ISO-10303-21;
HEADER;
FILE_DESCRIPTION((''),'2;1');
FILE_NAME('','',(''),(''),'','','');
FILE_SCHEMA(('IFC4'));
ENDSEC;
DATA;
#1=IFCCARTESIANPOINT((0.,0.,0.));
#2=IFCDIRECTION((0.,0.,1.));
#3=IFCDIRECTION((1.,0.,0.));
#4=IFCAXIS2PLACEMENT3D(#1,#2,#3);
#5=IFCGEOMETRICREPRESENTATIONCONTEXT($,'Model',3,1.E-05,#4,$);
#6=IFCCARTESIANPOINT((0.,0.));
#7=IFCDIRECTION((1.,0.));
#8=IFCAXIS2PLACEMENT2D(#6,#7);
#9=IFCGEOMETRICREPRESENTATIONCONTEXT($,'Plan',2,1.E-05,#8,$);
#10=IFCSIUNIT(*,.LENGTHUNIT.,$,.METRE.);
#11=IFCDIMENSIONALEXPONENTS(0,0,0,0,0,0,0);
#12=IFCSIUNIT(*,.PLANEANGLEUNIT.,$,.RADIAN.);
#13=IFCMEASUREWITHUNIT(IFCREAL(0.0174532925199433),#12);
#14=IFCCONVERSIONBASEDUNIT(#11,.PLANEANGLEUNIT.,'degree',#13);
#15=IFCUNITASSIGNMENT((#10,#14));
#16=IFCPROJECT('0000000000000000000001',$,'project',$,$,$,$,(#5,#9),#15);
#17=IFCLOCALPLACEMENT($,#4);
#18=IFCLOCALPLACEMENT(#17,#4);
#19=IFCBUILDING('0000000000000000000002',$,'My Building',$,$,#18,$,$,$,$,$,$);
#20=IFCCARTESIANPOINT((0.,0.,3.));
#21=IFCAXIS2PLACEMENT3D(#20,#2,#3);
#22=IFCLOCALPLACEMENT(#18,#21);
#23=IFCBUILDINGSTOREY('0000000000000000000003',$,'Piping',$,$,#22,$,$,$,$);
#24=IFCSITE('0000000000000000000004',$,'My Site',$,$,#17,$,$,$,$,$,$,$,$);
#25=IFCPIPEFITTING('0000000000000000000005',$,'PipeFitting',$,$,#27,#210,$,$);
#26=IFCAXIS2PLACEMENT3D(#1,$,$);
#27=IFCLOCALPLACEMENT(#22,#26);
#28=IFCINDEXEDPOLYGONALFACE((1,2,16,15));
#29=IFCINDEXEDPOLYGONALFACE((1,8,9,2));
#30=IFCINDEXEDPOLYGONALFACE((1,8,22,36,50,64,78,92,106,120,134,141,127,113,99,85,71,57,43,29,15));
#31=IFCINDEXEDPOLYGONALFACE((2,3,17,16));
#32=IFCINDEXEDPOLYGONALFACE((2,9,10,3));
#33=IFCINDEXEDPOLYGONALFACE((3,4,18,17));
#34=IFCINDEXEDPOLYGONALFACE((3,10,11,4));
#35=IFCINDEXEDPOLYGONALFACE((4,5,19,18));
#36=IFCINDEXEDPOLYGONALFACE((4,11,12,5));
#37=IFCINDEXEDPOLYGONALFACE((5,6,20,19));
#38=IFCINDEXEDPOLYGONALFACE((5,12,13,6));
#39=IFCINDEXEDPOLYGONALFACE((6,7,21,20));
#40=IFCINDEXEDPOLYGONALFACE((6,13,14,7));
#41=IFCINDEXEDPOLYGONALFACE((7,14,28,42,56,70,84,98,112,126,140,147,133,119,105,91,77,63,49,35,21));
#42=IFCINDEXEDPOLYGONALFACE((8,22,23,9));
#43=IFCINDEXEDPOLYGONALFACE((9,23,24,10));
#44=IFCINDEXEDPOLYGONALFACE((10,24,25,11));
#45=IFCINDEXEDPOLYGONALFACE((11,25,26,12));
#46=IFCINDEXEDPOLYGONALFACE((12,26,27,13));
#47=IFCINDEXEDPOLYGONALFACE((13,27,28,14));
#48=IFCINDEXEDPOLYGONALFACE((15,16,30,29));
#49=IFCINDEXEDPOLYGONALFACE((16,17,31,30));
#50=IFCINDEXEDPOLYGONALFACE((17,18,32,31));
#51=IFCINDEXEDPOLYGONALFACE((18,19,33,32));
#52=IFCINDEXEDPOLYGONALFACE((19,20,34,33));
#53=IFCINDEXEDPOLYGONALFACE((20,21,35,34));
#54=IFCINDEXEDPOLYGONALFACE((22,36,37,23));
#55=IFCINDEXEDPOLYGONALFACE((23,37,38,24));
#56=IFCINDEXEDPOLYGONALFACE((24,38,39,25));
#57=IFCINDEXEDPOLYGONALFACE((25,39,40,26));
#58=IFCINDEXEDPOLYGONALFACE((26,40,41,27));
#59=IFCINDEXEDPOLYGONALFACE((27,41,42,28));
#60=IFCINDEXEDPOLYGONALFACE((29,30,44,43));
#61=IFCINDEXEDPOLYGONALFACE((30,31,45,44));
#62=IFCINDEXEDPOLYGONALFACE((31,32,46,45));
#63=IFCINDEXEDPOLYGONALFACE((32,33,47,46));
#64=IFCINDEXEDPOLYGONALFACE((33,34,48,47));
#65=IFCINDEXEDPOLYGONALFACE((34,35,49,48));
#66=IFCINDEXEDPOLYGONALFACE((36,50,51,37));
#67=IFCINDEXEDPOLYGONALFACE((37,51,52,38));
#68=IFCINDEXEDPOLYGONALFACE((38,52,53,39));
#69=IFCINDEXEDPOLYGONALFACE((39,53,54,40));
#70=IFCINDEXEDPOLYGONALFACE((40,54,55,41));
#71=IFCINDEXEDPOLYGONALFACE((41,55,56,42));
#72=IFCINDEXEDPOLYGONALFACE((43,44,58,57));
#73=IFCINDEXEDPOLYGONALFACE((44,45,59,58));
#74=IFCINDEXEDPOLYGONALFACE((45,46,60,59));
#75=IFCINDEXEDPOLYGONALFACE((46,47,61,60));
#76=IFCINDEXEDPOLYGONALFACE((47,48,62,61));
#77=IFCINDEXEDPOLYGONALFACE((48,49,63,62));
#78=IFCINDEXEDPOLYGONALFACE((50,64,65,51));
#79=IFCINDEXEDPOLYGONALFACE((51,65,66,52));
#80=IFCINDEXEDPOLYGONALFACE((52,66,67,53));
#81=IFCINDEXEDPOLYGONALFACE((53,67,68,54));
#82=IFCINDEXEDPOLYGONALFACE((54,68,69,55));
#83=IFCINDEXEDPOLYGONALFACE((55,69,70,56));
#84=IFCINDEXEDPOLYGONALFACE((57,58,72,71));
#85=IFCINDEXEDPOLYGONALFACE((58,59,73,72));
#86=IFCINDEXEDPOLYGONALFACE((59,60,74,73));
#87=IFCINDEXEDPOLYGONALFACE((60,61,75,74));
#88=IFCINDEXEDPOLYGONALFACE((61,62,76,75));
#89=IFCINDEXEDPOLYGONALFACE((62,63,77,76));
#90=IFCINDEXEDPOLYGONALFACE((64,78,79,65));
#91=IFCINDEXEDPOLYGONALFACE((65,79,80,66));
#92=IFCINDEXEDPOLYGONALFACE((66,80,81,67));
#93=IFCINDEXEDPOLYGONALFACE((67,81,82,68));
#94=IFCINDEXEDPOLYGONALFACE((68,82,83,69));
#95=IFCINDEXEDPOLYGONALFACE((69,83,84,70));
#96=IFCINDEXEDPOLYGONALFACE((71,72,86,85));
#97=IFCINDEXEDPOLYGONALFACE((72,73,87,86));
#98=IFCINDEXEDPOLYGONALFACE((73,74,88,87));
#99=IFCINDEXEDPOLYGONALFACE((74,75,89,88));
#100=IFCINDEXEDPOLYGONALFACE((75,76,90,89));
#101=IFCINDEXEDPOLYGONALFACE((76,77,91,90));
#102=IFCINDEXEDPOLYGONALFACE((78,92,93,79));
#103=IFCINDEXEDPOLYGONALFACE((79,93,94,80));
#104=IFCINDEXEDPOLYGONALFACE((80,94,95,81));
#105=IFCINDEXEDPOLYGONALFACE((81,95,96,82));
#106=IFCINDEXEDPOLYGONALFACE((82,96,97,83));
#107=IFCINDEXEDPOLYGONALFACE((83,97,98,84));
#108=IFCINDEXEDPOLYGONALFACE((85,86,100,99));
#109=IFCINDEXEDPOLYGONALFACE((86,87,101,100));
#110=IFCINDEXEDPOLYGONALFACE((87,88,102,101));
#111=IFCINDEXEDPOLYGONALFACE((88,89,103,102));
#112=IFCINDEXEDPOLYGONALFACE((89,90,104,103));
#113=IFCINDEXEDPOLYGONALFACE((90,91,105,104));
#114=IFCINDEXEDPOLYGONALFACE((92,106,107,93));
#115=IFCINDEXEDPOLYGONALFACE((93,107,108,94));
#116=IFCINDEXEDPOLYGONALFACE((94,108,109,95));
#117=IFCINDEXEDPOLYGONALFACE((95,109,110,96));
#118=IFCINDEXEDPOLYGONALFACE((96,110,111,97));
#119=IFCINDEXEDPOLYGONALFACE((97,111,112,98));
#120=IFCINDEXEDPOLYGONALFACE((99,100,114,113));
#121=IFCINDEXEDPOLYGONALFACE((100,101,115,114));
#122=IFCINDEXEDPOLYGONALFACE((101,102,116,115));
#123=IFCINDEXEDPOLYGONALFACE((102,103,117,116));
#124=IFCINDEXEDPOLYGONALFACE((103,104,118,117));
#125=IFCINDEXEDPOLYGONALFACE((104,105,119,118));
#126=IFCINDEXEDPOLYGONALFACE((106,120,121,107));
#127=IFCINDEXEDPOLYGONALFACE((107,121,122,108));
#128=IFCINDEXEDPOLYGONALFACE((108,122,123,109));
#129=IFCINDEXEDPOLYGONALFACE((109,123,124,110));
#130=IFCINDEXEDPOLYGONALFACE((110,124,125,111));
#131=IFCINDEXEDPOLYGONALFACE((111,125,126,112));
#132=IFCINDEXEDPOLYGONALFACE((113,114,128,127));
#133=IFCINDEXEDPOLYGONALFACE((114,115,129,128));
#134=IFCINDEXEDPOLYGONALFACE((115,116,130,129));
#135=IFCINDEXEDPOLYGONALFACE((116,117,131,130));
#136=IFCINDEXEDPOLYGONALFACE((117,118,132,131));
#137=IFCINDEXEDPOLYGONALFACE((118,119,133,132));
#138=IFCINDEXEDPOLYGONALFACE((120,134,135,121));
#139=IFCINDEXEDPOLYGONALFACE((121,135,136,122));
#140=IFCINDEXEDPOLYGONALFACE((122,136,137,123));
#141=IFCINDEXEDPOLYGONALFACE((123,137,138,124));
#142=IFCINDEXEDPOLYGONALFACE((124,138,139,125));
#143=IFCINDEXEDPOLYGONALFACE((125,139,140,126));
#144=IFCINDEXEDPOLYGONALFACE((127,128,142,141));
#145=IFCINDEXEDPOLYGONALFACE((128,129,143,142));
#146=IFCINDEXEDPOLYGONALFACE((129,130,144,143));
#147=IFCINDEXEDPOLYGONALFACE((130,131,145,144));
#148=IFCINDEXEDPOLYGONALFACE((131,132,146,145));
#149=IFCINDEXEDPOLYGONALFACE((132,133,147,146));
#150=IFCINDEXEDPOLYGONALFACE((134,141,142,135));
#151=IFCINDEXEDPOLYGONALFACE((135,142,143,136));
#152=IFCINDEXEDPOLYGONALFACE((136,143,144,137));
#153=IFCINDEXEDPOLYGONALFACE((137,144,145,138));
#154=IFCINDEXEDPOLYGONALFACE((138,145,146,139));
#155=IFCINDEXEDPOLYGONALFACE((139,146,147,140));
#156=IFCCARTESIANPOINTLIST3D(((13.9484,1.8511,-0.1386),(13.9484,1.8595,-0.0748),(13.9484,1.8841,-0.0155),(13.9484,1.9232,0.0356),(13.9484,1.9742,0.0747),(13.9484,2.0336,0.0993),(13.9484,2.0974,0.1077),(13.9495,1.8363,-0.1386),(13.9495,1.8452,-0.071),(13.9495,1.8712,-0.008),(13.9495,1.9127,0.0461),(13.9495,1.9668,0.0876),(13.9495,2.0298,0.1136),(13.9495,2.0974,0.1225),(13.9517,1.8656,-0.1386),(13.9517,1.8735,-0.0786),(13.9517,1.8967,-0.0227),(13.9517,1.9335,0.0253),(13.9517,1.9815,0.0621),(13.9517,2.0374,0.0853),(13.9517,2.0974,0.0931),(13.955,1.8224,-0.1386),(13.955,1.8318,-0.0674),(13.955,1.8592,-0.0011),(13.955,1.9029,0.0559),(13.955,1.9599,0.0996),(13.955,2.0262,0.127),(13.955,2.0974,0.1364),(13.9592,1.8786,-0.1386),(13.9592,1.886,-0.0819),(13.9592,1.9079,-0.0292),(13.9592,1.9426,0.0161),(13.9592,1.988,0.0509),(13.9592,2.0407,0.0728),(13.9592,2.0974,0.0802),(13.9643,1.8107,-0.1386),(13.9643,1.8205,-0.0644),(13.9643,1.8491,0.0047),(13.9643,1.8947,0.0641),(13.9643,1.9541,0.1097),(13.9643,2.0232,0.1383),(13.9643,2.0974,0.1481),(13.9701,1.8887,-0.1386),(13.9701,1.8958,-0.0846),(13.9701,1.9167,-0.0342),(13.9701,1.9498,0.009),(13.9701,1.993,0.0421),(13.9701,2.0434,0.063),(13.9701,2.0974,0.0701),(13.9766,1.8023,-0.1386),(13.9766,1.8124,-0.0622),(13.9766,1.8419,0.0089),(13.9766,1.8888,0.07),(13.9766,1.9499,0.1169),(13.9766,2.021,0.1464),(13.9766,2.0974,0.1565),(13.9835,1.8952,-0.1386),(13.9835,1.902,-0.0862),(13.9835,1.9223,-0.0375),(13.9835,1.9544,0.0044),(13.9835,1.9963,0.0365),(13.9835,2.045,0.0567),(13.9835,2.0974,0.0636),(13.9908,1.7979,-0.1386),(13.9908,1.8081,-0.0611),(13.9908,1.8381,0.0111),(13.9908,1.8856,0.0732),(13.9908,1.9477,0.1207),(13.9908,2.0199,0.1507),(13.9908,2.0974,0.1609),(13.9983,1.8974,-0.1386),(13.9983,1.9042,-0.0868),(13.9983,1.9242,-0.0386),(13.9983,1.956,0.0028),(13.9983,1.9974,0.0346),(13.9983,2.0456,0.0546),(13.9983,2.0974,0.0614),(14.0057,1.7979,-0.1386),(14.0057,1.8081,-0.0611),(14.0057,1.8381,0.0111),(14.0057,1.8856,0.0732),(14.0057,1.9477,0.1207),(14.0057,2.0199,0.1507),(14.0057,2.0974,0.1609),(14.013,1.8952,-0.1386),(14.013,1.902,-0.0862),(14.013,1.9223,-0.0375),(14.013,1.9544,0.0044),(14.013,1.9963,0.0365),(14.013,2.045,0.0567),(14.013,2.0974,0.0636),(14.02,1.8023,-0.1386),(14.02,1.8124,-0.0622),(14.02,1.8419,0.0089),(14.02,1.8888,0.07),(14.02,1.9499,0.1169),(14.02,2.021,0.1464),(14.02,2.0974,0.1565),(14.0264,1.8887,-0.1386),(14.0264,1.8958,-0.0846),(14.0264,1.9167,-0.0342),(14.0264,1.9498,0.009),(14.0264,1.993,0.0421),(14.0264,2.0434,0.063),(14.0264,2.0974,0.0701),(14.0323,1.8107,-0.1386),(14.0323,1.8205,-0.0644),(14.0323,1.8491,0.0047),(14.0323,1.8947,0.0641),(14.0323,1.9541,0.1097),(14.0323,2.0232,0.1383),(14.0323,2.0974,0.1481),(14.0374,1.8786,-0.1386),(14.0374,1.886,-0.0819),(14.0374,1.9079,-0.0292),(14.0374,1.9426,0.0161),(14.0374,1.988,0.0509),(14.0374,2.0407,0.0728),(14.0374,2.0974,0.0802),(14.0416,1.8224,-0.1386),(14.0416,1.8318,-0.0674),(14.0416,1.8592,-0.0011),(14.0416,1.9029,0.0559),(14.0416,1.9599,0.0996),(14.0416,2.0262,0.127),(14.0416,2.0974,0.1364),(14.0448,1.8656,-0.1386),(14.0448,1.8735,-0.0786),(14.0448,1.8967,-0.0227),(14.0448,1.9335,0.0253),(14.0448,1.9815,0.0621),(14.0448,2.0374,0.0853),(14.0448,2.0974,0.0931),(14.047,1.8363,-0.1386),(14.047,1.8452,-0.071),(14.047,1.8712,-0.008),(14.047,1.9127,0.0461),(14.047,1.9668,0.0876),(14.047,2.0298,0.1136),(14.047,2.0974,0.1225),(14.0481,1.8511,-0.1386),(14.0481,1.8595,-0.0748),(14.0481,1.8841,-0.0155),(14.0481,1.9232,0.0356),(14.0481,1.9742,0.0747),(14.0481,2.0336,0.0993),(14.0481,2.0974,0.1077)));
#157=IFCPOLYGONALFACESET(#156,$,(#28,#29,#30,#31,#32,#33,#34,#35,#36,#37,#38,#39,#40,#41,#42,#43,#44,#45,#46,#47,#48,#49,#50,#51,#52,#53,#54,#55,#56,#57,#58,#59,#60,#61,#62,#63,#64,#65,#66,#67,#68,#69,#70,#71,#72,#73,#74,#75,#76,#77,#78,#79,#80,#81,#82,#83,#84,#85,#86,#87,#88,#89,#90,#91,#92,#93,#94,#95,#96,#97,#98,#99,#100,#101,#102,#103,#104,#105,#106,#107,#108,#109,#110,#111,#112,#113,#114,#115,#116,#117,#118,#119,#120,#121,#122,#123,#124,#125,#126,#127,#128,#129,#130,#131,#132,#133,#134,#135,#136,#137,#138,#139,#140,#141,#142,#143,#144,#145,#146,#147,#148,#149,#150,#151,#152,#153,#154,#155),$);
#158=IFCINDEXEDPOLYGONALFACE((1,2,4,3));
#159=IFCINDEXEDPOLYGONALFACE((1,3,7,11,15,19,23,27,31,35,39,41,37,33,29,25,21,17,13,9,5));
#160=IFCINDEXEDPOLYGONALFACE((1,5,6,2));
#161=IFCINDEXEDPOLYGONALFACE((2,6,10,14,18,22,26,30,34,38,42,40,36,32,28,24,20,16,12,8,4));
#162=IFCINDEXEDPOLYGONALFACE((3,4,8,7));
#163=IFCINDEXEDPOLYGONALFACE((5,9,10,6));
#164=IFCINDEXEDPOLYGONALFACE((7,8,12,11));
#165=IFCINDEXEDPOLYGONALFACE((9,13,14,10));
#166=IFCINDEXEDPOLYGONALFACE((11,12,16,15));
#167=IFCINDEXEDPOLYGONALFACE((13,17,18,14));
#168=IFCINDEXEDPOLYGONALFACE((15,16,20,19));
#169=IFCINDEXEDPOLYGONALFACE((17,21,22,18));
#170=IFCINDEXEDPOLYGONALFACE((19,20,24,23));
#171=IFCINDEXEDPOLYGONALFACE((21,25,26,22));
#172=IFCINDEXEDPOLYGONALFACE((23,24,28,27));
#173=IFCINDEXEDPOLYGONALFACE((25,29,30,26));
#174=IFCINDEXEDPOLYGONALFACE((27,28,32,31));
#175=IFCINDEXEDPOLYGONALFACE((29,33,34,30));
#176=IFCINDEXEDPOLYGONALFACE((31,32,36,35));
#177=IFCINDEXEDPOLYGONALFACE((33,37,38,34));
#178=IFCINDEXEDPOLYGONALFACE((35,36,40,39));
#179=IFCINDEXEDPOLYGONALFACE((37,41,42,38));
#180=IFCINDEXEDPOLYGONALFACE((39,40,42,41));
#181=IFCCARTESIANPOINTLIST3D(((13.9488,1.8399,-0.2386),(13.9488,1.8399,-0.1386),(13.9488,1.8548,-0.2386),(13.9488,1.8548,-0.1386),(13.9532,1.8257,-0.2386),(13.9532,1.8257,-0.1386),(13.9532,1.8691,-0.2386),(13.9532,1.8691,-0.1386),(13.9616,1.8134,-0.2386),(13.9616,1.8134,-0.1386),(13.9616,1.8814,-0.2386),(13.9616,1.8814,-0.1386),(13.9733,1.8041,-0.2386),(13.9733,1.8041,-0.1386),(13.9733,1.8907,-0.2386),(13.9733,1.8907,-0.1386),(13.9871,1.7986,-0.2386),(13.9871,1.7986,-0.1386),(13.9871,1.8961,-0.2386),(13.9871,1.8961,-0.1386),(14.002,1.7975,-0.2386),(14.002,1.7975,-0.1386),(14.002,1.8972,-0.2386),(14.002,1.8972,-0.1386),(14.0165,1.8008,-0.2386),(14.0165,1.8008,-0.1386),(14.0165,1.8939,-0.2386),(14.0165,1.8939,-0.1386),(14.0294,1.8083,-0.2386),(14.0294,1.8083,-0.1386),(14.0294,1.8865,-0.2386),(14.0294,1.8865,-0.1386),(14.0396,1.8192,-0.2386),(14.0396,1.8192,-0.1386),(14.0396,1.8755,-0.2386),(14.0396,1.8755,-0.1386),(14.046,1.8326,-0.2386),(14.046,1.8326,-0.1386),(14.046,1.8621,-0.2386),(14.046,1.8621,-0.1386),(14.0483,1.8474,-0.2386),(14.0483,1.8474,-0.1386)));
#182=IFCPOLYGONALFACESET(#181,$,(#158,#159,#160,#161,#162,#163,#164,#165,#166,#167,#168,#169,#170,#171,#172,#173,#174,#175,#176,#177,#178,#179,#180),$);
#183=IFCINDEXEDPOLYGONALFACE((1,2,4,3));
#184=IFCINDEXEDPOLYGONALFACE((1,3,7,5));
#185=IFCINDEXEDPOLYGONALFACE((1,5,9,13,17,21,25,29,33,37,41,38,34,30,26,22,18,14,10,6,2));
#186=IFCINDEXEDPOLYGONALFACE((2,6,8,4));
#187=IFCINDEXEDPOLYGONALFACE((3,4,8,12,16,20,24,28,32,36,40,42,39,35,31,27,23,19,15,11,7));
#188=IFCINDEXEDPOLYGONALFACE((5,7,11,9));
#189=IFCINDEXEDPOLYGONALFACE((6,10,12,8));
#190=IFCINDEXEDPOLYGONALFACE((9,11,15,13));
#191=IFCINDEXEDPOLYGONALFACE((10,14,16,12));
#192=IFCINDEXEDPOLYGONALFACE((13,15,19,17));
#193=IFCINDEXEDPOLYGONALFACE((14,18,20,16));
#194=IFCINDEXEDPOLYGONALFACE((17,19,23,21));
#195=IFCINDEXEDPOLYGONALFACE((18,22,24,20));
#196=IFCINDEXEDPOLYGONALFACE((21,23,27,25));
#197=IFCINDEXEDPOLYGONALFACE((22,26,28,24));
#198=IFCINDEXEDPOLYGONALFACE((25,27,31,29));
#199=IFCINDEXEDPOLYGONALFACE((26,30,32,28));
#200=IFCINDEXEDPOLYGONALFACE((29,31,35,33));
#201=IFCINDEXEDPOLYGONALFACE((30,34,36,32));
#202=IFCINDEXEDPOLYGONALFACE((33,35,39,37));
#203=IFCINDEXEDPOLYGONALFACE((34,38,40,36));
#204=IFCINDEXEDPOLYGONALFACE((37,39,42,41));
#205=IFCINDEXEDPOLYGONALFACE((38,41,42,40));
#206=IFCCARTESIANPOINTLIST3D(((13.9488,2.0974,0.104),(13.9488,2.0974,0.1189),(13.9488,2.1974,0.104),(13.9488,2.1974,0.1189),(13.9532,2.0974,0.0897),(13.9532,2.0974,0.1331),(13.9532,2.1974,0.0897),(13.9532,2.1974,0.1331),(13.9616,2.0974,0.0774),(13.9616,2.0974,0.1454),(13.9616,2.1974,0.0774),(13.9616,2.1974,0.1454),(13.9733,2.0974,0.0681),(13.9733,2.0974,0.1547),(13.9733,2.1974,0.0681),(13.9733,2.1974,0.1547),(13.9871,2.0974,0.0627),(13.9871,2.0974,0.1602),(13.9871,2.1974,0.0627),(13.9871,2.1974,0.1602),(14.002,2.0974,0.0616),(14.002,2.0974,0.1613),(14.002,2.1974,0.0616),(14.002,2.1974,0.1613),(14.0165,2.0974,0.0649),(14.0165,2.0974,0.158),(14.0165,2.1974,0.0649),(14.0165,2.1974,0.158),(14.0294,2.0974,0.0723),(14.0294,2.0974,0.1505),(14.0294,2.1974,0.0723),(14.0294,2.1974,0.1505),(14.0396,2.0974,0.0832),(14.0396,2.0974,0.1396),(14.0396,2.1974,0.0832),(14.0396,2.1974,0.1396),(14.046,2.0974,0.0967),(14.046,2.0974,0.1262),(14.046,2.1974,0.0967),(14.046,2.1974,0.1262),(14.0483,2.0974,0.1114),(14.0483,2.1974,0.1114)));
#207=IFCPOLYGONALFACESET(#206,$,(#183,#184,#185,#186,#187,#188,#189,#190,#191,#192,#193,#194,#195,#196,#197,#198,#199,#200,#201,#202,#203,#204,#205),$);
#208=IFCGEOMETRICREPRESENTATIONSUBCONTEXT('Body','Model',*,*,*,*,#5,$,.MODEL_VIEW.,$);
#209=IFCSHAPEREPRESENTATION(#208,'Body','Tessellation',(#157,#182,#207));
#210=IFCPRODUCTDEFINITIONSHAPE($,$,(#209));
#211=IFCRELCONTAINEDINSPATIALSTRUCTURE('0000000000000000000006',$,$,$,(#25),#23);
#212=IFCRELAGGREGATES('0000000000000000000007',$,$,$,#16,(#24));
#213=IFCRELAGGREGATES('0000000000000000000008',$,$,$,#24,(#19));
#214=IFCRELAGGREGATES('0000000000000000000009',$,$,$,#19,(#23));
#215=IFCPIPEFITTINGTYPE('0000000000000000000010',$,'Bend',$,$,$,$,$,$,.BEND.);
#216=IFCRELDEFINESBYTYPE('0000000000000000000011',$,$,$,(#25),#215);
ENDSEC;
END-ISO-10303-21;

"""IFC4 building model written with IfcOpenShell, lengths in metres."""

from ifc_helpers import new_model, entity, si_unit, converted_unit, frame, origin_with_axes, origin_2d_with_axis, place, context, subcontext, project, spatial, circle, extrude, source, transform, mapped, type_object, type_shapes, element, save


model = new_model("IFC4")

# Units and contexts
model_context = context("Model", 3, precision=1e-05, world=origin_with_axes())
plan_context = context("Plan", 2, precision=1e-05, world=origin_2d_with_axis())
body_context = subcontext(model_context, "Body", "Model", "MODEL_VIEW")
ifc_project = project(units=[si_unit("LENGTHUNIT", "METRE"), converted_unit("PLANEANGLEUNIT", "degree", entity("IfcReal", 0.0174532925199433), si_unit("PLANEANGLEUNIT", "RADIAN"), dimensions=[0, 0, 0, 0, 0, 0, 0])], contexts=[model_context, plan_context])

# Site, building, storey
site_placement = place(None, origin_with_axes())
site = spatial("IfcSite", under=ifc_project, at=site_placement, Name="My Site")
building_placement = place(site_placement, origin_with_axes())
building = spatial("IfcBuilding", under=site, at=building_placement, Name="My Building")
storey_placement = place(building_placement, frame((0.0, 0.0, 3.0), z_axis=(0.0, 0.0, 1.0), x_axis=(1.0, 0.0, 0.0)))
storey = spatial("IfcBuildingStorey", under=building, at=storey_placement, Name="Piping")

# Pipe fitting
pipe_fitting_type_1 = type_object("IfcPipeFittingType", Name="Bend", PredefinedType="BEND")
shared_shape = source(origin_with_axes(), body_context, "Body", "SolidModel", [
    entity("IfcSweptDiskSolid", entity("IfcIndexedPolyCurve", entity("IfcCartesianPointList3D", [[0.0, 0.0, -0.1], [0.0, -0.0732, -0.2768], [0.0, -0.25, -0.35]]), [entity("IfcArcIndex", [1, 2, 3])]), 0.05),
    extrude(circle(Radius=0.05), origin_with_axes(), (0.0, 0.0, -1.0), 0.1),
    extrude(circle(Radius=0.05), frame((0.0, -0.25, -0.35), z_axis=(0.0, -1.0, 0.0), x_axis=(1.0, 0.0, 0.0)), (0.0, 0.0, 1.0), 0.1),
])
type_shapes(pipe_fitting_type_1, [shared_shape])
for number, where, z_axis, x_axis, name in (
    (1, (13.9983, 1.8474, -0.2386), (0.0, 0.0, -1.0), (1.0, 0.0, 0.0), "PipeFitting"),
):
    element("IfcPipeFitting", number, at=place(storey_placement, frame(where, z_axis=z_axis, x_axis=x_axis)), inside=storey, type_object=pipe_fitting_type_1, Name=name, context=body_context, shape_type="MappedRepresentation", body=[
        mapped(shared_shape, transform((0.0, 0.0, 0.0), x_axis=(1.0, 0.0, 0.0), y_axis=(0.0, 1.0, 0.0), z_axis=(0.0, 0.0, 1.0), scale=1.0)),
    ])

save(model, "model.ifc")
